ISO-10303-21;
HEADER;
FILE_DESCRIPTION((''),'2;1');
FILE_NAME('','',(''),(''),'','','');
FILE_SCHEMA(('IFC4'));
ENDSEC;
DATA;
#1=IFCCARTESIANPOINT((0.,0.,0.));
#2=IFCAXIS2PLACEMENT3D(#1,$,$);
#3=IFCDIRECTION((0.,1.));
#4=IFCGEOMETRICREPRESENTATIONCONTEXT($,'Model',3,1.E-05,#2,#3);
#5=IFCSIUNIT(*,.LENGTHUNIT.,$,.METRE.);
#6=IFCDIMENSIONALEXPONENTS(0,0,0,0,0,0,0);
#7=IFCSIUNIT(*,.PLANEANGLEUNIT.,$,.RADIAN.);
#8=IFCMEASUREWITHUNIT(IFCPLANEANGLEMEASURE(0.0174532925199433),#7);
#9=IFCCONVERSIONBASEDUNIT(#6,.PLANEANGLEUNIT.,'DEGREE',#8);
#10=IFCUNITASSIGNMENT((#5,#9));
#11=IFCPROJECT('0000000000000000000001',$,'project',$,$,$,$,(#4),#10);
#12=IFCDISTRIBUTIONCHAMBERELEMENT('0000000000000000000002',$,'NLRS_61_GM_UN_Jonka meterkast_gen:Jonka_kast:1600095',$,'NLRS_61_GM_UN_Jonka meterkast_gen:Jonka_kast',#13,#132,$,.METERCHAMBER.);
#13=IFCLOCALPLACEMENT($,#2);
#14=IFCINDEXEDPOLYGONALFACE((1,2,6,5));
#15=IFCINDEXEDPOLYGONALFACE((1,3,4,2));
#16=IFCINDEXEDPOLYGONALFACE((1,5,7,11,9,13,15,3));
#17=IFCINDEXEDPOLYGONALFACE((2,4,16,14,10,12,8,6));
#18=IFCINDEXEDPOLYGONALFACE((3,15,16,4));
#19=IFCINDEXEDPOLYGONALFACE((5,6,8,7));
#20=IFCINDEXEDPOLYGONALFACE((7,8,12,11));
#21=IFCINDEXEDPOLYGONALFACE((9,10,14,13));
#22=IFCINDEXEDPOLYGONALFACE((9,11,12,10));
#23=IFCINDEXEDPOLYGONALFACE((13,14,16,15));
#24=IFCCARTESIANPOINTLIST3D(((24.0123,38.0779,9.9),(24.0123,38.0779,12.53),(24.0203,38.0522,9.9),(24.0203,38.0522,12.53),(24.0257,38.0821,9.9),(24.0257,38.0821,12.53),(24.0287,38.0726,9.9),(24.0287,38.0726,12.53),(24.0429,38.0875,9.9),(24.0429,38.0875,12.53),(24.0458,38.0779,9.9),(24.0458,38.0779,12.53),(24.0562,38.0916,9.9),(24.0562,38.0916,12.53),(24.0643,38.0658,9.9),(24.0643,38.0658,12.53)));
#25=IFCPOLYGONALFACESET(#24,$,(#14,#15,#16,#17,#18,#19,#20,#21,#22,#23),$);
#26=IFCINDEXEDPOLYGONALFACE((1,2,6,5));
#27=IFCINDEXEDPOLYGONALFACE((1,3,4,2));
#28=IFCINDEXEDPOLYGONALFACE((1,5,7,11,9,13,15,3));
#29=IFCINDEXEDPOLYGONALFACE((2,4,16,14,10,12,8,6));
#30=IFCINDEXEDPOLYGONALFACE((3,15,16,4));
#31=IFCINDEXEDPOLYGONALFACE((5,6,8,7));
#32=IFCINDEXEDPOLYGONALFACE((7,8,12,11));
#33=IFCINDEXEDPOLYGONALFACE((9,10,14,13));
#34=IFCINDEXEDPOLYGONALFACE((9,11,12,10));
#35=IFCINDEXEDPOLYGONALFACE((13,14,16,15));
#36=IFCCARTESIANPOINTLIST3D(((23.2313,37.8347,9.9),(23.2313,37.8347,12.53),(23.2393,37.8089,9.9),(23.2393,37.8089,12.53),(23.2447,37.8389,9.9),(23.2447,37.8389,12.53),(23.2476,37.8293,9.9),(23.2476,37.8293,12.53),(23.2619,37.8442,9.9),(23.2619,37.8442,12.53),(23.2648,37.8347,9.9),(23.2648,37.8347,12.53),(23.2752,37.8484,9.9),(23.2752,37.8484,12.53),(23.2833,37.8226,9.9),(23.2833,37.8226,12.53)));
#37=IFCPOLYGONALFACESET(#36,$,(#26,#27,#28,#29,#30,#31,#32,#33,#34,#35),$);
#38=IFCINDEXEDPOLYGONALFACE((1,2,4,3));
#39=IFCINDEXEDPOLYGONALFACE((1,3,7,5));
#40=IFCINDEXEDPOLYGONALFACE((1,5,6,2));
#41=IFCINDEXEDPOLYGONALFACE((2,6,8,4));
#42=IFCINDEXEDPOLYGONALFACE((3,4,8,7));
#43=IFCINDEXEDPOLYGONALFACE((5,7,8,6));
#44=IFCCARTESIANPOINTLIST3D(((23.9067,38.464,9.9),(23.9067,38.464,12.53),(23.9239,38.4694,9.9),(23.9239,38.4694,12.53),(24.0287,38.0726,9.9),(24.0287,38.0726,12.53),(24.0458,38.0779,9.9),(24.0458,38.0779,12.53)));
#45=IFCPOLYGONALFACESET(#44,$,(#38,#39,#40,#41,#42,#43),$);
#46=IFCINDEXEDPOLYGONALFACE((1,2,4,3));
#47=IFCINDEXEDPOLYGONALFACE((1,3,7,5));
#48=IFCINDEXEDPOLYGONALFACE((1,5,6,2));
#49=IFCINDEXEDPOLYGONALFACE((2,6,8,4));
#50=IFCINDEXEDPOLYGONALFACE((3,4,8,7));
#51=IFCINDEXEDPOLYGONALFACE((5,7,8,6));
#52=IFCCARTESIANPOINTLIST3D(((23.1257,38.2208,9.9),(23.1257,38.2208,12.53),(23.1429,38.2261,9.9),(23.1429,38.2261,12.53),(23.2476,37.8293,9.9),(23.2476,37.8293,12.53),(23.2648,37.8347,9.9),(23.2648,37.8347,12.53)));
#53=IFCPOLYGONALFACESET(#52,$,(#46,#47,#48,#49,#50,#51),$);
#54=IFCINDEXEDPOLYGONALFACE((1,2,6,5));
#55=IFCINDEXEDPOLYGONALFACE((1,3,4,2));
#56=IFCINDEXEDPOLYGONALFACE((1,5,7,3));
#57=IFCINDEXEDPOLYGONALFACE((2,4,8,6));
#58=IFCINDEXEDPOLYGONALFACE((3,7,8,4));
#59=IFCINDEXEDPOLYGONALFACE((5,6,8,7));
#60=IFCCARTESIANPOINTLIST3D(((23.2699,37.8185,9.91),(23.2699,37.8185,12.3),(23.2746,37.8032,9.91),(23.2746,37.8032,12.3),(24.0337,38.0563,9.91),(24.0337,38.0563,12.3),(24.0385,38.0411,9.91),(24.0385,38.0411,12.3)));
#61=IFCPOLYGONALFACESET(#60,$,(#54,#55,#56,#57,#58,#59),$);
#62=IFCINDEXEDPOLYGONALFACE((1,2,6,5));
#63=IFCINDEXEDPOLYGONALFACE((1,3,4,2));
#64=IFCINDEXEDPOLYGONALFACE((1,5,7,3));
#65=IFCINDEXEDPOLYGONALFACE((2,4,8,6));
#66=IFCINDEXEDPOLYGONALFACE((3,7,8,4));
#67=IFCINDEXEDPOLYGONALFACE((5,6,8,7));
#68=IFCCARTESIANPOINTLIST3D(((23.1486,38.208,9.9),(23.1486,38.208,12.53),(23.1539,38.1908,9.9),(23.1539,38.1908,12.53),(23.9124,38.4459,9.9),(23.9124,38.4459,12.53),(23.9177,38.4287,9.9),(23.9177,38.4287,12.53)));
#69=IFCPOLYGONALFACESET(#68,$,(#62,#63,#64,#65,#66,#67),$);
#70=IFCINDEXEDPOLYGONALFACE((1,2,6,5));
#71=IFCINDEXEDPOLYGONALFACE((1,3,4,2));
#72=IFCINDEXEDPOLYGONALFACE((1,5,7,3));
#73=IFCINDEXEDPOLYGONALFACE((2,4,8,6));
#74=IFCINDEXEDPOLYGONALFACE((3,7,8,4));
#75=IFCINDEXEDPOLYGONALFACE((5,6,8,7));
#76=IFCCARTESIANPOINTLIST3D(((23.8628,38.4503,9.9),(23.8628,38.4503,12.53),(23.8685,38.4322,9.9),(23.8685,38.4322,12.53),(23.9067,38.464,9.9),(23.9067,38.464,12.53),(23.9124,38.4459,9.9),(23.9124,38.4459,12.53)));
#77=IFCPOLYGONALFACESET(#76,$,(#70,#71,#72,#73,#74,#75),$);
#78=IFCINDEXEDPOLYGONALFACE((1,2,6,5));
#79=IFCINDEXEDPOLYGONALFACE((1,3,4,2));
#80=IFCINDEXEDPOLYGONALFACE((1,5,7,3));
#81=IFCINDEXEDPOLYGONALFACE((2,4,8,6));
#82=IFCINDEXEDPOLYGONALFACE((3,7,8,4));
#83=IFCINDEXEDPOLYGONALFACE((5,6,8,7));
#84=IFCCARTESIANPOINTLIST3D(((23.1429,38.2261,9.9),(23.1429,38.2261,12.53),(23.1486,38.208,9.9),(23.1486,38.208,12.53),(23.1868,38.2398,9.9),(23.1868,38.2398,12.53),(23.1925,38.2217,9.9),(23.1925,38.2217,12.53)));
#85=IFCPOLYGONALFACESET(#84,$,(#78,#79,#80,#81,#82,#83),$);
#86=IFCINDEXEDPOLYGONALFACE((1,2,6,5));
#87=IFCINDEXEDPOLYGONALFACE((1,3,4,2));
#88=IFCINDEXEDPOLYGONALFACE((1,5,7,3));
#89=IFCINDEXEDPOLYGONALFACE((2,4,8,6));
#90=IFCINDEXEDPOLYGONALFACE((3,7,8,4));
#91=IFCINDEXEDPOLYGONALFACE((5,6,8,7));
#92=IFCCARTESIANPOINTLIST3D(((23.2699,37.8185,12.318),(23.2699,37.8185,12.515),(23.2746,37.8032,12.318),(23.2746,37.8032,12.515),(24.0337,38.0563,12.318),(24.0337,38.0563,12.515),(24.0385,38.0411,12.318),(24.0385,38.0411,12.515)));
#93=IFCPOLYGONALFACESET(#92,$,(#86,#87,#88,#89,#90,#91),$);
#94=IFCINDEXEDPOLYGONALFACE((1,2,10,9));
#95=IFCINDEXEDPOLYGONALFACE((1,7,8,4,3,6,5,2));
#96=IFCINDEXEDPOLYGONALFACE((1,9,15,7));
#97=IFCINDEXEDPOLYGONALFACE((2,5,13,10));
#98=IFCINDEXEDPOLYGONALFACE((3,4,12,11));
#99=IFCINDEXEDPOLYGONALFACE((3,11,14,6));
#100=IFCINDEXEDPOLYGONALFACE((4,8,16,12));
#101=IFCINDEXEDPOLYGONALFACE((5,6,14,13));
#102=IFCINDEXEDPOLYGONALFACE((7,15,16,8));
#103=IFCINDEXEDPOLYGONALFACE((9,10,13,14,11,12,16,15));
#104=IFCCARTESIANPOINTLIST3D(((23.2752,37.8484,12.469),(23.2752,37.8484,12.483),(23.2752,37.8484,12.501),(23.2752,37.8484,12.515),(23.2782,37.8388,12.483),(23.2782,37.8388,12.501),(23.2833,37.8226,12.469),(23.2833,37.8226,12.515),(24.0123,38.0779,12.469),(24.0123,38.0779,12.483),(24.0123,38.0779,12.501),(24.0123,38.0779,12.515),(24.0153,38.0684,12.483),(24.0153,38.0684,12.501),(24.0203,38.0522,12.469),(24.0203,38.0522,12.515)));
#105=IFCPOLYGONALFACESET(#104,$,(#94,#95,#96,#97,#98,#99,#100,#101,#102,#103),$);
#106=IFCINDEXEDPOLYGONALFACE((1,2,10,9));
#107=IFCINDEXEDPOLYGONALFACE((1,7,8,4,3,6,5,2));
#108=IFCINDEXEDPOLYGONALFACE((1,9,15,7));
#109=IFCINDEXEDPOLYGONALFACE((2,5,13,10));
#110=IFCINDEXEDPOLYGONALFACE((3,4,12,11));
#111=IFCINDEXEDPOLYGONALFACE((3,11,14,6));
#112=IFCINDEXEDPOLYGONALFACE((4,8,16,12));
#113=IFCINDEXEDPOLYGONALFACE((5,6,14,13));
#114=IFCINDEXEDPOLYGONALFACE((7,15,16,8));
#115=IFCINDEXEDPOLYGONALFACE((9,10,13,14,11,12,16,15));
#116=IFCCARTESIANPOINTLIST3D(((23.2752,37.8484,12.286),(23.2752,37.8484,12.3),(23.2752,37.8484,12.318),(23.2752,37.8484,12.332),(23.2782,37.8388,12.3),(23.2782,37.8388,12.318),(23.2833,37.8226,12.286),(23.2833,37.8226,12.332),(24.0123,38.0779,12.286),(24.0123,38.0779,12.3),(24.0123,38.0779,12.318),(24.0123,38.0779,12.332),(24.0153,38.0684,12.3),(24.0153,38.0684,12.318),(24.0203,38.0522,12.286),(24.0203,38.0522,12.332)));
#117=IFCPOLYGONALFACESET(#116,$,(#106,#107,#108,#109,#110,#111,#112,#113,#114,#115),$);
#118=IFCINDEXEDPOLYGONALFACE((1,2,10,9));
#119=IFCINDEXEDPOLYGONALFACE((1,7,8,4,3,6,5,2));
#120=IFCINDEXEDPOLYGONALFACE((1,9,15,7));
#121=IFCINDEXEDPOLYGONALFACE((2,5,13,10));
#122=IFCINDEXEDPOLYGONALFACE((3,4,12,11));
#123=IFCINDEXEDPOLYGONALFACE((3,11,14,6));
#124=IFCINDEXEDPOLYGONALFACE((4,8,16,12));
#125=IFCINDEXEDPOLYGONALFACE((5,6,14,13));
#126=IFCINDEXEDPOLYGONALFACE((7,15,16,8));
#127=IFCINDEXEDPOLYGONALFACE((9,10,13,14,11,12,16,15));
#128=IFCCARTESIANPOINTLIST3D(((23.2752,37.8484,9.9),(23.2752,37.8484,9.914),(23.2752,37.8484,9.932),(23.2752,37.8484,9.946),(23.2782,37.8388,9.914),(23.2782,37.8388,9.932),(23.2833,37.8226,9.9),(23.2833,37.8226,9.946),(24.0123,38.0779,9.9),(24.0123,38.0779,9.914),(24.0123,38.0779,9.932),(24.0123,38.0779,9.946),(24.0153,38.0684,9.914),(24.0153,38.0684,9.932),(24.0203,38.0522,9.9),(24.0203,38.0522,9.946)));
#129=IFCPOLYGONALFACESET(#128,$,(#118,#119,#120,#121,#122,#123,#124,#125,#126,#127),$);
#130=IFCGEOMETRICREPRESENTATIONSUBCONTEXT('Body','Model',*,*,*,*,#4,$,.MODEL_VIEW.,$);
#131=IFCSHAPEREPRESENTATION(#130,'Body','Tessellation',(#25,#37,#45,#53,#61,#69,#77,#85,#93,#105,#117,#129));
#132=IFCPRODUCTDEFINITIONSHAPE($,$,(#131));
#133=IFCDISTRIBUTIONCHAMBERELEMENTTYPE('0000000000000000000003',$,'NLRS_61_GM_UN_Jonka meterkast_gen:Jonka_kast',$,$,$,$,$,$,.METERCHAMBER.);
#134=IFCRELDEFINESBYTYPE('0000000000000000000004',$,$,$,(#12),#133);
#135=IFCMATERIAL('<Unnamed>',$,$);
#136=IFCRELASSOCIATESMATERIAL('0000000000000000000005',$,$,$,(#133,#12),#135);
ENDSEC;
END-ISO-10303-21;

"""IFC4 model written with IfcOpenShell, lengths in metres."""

from ifc_helpers import new_model, entity, si_unit, converted_unit, direction, frame, origin, place, context, subcontext, project, indexed_curve, outline, extrude, source, transform, mapped, material, type_object, element, save


model = new_model("IFC4")

# Units and contexts
model_context = context("Model", 3, precision=1e-05, world=origin(), true_north=direction((0.0, 1.0)))
body_context = subcontext(model_context, "Body", "Model", "MODEL_VIEW")
ifc_project = project(units=[si_unit("LENGTHUNIT", "METRE"), converted_unit("PLANEANGLEUNIT", "DEGREE", entity("IfcPlaneAngleMeasure", 0.0174532925199433), si_unit("PLANEANGLEUNIT", "RADIAN"), dimensions=[0, 0, 0, 0, 0, 0, 0])], contexts=[model_context])

# Shared definitions
ifc_material = material(Name="<Unnamed>")
distribution_chamber_element_type = type_object("IfcDistributionChamberElementType", Name="NLRS_61_GM_UN_Jonka meterkast_gen:Jonka_kast", PredefinedType="METERCHAMBER", material=ifc_material)
placement_1 = place(None, frame((13.1348, 11.9886, 0.0), z_axis=(0.0, 0.0, 1.0), x_axis=(0.954771, 0.297342, 0.0)))
placement_2 = place(placement_1, origin())
placement_3 = place(placement_2, frame((0.0, 0.0, 9.9)))

# Distribution chamber element
shared_shape_1 = source(origin(), body_context, "Body", "SweptSolid", [
    extrude(outline(indexed_curve([(-0.023, -0.0093), (-0.009, -0.0093), (-0.009, 0.0007), (0.009, 0.0007), (0.009, -0.0093), (0.023, -0.0093), (0.023, 0.0178), (-0.023, 0.0178), (-0.023, -0.0093)], self_intersect=False)), frame((-0.409, 0.4092, 0.0)), (0.0, 0.0, 1.0), 2.63),
    extrude(outline(indexed_curve([(-0.023, -0.0093), (-0.009, -0.0093), (-0.009, 0.0007), (0.009, 0.0007), (0.009, -0.0093), (0.023, -0.0093), (0.023, 0.0178), (-0.023, 0.0178), (-0.023, -0.0093)], self_intersect=False)), frame((0.409, 0.4092, 0.0)), (0.0, 0.0, 1.0), 2.63),
    extrude(outline(indexed_curve([(-0.009, -0.205), (0.009, -0.205), (0.009, 0.205), (-0.009, 0.205), (-0.009, -0.205)], self_intersect=False)), frame((-0.409, 0.205, 0.0)), (0.0, 0.0, 1.0), 2.63),
    extrude(outline(indexed_curve([(-0.009, -0.205), (0.009, -0.205), (0.009, 0.205), (-0.009, 0.205), (-0.009, -0.205)], self_intersect=False)), frame((0.409, 0.205, 0.0)), (0.0, 0.0, 1.0), 2.63),
    extrude(outline(indexed_curve([(-0.008, -0.4), (0.008, -0.4), (0.008, 0.4), (-0.008, 0.4), (-0.008, -0.4)], self_intersect=False)), frame((0.0, 0.435, 0.01), z_axis=(0.0, 0.0, 1.0), x_axis=(0.0, 1.0, 0.0)), (0.0, 0.0, 1.0), 2.39),
    extrude(outline(indexed_curve([(-0.009, -0.4), (0.009, -0.4), (0.009, 0.4), (-0.009, 0.4), (-0.009, -0.4)], self_intersect=False)), frame((0.0, 0.028, 0.0), z_axis=(0.0, 0.0, 1.0), x_axis=(0.0, 1.0, 0.0)), (0.0, 0.0, 1.0), 2.63),
    extrude(outline(indexed_curve([(-0.0095, -0.023), (0.0095, -0.023), (0.0095, 0.023), (-0.0095, 0.023), (-0.0095, -0.023)], self_intersect=False)), frame((-0.377, 0.0095, 0.0), z_axis=(0.0, 0.0, 1.0), x_axis=(0.0, 1.0, 0.0)), (0.0, 0.0, 1.0), 2.63),
    extrude(outline(indexed_curve([(-0.0095, -0.023), (0.0095, -0.023), (0.0095, 0.023), (-0.0095, 0.023), (-0.0095, -0.023)], self_intersect=False)), frame((0.377, 0.0095, 0.0), z_axis=(0.0, 0.0, 1.0), x_axis=(0.0, 1.0, 0.0)), (0.0, 0.0, 1.0), 2.63),
    extrude(outline(indexed_curve([(-0.008, -0.4), (0.008, -0.4), (0.008, 0.4), (-0.008, 0.4), (-0.008, -0.4)], self_intersect=False)), frame((0.0, 0.435, 2.418), z_axis=(0.0, 0.0, 1.0), x_axis=(0.0, 1.0, 0.0)), (0.0, 0.0, 1.0), 0.197),
    extrude(outline(indexed_curve([(-0.0178, -0.023), (0.0093, -0.023), (0.0093, -0.009), (-0.0007, -0.009), (-0.0007, 0.009), (0.0093, 0.009), (0.0093, 0.023), (-0.0178, 0.023), (-0.0178, -0.023)], self_intersect=False)), frame((-0.386, 0.4092, 2.592), z_axis=(1.0, 0.0, 0.0), x_axis=(0.0, -1.0, 0.0)), (0.0, 0.0, 1.0), 0.772),
    extrude(outline(indexed_curve([(-0.0178, -0.023), (0.0093, -0.023), (0.0093, -0.009), (-0.0007, -0.009), (-0.0007, 0.009), (0.0093, 0.009), (0.0093, 0.023), (-0.0178, 0.023), (-0.0178, -0.023)], self_intersect=False)), frame((-0.386, 0.4092, 2.409), z_axis=(1.0, 0.0, 0.0), x_axis=(0.0, -1.0, 0.0)), (0.0, 0.0, 1.0), 0.772),
    extrude(outline(indexed_curve([(-0.0178, -0.023), (0.0093, -0.023), (0.0093, -0.009), (-0.0007, -0.009), (-0.0007, 0.009), (0.0093, 0.009), (0.0093, 0.023), (-0.0178, 0.023), (-0.0178, -0.023)], self_intersect=False)), frame((-0.386, 0.4092, 0.023), z_axis=(1.0, 0.0, 0.0), x_axis=(0.0, -1.0, 0.0)), (0.0, 0.0, 1.0), 0.772),
])
placement_4 = place(placement_3, origin())
distribution_chamber_element_1_placement = place(placement_4, frame((17.757, 22.075, 0.0), z_axis=(0.0, 0.0, 1.0), x_axis=(-1.0, 0.0, 0.0)))
element("IfcDistributionChamberElement", 1, at=distribution_chamber_element_1_placement, type_object=distribution_chamber_element_type, material=ifc_material, Name="NLRS_61_GM_UN_Jonka meterkast_gen:Jonka_kast:1600095", ObjectType="NLRS_61_GM_UN_Jonka meterkast_gen:Jonka_kast", PredefinedType="METERCHAMBER", context=body_context, shape_type="MappedRepresentation", body=[
    mapped(shared_shape_1, transform((0.0, 0.0, 0.0), scale=1.0)),
])

save(model, "model.ifc")
